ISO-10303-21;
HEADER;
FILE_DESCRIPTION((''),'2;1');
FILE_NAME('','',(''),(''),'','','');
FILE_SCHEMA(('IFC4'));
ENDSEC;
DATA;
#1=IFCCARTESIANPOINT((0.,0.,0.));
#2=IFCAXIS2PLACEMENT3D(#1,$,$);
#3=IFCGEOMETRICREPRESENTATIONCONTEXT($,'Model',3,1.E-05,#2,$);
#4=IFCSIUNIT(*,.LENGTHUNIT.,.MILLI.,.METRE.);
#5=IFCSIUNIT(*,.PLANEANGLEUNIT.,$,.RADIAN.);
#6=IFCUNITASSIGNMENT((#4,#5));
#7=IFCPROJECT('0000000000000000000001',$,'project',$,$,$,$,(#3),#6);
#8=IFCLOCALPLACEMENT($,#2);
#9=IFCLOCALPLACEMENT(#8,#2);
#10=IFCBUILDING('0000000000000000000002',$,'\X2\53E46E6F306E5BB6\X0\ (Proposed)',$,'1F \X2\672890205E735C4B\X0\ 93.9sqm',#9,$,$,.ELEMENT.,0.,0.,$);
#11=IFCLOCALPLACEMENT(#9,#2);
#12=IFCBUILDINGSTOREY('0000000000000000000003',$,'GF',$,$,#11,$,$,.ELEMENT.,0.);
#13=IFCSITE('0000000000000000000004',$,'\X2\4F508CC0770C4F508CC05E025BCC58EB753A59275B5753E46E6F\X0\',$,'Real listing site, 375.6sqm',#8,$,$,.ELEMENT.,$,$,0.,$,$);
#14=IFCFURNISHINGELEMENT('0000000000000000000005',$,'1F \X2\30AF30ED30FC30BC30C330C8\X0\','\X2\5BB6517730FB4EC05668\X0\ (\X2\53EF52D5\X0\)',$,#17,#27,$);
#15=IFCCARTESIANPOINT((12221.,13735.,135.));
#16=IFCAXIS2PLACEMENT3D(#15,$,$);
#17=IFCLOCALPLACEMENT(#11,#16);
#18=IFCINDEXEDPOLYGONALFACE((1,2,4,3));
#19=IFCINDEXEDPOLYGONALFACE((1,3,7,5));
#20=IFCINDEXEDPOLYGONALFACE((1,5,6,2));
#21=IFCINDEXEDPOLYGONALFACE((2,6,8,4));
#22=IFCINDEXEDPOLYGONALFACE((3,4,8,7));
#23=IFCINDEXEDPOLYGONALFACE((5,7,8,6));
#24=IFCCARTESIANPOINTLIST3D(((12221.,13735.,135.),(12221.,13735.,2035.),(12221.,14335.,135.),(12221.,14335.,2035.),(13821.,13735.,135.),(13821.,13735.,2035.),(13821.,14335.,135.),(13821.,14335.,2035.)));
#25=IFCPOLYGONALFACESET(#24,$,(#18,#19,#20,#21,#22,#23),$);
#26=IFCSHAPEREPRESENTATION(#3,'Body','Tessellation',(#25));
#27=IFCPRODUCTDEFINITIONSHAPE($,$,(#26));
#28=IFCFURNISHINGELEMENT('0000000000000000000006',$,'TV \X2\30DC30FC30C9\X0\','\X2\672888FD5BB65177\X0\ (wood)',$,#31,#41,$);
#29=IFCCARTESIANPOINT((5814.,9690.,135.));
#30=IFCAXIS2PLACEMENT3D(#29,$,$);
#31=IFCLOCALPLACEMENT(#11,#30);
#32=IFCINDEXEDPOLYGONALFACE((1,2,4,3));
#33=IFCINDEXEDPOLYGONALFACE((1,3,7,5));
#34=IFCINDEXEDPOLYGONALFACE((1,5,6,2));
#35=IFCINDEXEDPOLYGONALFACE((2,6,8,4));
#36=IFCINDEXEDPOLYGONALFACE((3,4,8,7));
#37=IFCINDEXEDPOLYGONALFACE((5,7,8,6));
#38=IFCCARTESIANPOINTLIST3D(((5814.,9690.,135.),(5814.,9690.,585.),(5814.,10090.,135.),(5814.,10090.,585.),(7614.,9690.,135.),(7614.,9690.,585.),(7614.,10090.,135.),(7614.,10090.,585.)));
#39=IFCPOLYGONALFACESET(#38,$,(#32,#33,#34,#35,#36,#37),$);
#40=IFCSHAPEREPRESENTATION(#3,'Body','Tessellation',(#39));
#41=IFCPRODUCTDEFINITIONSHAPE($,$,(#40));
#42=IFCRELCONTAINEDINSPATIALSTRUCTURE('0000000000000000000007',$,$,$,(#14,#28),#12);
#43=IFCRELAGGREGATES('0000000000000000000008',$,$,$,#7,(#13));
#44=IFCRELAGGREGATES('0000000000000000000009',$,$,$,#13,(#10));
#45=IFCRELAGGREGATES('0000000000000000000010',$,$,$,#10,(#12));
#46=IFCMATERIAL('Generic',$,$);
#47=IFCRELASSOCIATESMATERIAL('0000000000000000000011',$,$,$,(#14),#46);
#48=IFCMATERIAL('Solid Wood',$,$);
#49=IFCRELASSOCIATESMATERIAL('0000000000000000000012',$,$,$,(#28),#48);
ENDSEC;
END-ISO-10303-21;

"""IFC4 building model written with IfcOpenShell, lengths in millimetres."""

from ifc_helpers import new_model, si_unit, frame, frame_2d, origin, place, context, project, spatial, rectangle, extrude, material, element, save


model = new_model("IFC4")

# Units and contexts
model_context = context("Model", 3, precision=1e-05, world=origin())
ifc_project = project(units=[si_unit("LENGTHUNIT", "METRE", prefix="MILLI"), si_unit("PLANEANGLEUNIT", "RADIAN")], contexts=[model_context])

# Site, building, storey
site_placement = place(None, origin())
site = spatial("IfcSite", under=ifc_project, at=site_placement, Name="佐賀県佐賀市富士町大字古湯", ObjectType="Real listing site, 375.6sqm", CompositionType="ELEMENT", RefElevation=0.0)
building_placement = place(site_placement, origin())
building = spatial("IfcBuilding", under=site, at=building_placement, Name="古湯の家 (Proposed)", ObjectType="1F 木造平屋 93.9sqm", CompositionType="ELEMENT", ElevationOfRefHeight=0.0, ElevationOfTerrain=0.0)
storey_placement = place(building_placement, origin())
storey = spatial("IfcBuildingStorey", under=building, at=storey_placement, Name="GF", CompositionType="ELEMENT", Elevation=0.0)

# Shared definitions
ifc_material_1 = material(Name="Solid Wood")

# Shared definitions
ifc_material_2 = material(Name="Generic")

# Furnishing elements
furnishing_1_placement = place(storey_placement, frame((12221.0, 13735.0, 135.0)))
element("IfcFurnishingElement", 1, at=furnishing_1_placement, inside=storey, material=ifc_material_2, Name="1F クローゼット", Description="家具・什器 (可動)", context=model_context, shape_type="SweptSolid", body=[
    extrude(rectangle(XDim=1600.0, YDim=600.0, at=frame_2d((800.0, 300.0))), frame((12221.0, 13735.0, 135.0)), (0.0, 0.0, 1.0), 1900.0),
])
furnishing_2_placement = place(storey_placement, frame((5814.0, 9690.0, 135.0)))
element("IfcFurnishingElement", 2, at=furnishing_2_placement, inside=storey, material=ifc_material_1, Name="TV ボード", Description="木製家具 (wood)", context=model_context, shape_type="SweptSolid", body=[
    extrude(rectangle(XDim=1800.0, YDim=400.0, at=frame_2d((900.0, 200.0))), frame((5814.0, 9690.0, 135.0)), (0.0, 0.0, 1.0), 450.0),
])

save(model, "model.ifc")
